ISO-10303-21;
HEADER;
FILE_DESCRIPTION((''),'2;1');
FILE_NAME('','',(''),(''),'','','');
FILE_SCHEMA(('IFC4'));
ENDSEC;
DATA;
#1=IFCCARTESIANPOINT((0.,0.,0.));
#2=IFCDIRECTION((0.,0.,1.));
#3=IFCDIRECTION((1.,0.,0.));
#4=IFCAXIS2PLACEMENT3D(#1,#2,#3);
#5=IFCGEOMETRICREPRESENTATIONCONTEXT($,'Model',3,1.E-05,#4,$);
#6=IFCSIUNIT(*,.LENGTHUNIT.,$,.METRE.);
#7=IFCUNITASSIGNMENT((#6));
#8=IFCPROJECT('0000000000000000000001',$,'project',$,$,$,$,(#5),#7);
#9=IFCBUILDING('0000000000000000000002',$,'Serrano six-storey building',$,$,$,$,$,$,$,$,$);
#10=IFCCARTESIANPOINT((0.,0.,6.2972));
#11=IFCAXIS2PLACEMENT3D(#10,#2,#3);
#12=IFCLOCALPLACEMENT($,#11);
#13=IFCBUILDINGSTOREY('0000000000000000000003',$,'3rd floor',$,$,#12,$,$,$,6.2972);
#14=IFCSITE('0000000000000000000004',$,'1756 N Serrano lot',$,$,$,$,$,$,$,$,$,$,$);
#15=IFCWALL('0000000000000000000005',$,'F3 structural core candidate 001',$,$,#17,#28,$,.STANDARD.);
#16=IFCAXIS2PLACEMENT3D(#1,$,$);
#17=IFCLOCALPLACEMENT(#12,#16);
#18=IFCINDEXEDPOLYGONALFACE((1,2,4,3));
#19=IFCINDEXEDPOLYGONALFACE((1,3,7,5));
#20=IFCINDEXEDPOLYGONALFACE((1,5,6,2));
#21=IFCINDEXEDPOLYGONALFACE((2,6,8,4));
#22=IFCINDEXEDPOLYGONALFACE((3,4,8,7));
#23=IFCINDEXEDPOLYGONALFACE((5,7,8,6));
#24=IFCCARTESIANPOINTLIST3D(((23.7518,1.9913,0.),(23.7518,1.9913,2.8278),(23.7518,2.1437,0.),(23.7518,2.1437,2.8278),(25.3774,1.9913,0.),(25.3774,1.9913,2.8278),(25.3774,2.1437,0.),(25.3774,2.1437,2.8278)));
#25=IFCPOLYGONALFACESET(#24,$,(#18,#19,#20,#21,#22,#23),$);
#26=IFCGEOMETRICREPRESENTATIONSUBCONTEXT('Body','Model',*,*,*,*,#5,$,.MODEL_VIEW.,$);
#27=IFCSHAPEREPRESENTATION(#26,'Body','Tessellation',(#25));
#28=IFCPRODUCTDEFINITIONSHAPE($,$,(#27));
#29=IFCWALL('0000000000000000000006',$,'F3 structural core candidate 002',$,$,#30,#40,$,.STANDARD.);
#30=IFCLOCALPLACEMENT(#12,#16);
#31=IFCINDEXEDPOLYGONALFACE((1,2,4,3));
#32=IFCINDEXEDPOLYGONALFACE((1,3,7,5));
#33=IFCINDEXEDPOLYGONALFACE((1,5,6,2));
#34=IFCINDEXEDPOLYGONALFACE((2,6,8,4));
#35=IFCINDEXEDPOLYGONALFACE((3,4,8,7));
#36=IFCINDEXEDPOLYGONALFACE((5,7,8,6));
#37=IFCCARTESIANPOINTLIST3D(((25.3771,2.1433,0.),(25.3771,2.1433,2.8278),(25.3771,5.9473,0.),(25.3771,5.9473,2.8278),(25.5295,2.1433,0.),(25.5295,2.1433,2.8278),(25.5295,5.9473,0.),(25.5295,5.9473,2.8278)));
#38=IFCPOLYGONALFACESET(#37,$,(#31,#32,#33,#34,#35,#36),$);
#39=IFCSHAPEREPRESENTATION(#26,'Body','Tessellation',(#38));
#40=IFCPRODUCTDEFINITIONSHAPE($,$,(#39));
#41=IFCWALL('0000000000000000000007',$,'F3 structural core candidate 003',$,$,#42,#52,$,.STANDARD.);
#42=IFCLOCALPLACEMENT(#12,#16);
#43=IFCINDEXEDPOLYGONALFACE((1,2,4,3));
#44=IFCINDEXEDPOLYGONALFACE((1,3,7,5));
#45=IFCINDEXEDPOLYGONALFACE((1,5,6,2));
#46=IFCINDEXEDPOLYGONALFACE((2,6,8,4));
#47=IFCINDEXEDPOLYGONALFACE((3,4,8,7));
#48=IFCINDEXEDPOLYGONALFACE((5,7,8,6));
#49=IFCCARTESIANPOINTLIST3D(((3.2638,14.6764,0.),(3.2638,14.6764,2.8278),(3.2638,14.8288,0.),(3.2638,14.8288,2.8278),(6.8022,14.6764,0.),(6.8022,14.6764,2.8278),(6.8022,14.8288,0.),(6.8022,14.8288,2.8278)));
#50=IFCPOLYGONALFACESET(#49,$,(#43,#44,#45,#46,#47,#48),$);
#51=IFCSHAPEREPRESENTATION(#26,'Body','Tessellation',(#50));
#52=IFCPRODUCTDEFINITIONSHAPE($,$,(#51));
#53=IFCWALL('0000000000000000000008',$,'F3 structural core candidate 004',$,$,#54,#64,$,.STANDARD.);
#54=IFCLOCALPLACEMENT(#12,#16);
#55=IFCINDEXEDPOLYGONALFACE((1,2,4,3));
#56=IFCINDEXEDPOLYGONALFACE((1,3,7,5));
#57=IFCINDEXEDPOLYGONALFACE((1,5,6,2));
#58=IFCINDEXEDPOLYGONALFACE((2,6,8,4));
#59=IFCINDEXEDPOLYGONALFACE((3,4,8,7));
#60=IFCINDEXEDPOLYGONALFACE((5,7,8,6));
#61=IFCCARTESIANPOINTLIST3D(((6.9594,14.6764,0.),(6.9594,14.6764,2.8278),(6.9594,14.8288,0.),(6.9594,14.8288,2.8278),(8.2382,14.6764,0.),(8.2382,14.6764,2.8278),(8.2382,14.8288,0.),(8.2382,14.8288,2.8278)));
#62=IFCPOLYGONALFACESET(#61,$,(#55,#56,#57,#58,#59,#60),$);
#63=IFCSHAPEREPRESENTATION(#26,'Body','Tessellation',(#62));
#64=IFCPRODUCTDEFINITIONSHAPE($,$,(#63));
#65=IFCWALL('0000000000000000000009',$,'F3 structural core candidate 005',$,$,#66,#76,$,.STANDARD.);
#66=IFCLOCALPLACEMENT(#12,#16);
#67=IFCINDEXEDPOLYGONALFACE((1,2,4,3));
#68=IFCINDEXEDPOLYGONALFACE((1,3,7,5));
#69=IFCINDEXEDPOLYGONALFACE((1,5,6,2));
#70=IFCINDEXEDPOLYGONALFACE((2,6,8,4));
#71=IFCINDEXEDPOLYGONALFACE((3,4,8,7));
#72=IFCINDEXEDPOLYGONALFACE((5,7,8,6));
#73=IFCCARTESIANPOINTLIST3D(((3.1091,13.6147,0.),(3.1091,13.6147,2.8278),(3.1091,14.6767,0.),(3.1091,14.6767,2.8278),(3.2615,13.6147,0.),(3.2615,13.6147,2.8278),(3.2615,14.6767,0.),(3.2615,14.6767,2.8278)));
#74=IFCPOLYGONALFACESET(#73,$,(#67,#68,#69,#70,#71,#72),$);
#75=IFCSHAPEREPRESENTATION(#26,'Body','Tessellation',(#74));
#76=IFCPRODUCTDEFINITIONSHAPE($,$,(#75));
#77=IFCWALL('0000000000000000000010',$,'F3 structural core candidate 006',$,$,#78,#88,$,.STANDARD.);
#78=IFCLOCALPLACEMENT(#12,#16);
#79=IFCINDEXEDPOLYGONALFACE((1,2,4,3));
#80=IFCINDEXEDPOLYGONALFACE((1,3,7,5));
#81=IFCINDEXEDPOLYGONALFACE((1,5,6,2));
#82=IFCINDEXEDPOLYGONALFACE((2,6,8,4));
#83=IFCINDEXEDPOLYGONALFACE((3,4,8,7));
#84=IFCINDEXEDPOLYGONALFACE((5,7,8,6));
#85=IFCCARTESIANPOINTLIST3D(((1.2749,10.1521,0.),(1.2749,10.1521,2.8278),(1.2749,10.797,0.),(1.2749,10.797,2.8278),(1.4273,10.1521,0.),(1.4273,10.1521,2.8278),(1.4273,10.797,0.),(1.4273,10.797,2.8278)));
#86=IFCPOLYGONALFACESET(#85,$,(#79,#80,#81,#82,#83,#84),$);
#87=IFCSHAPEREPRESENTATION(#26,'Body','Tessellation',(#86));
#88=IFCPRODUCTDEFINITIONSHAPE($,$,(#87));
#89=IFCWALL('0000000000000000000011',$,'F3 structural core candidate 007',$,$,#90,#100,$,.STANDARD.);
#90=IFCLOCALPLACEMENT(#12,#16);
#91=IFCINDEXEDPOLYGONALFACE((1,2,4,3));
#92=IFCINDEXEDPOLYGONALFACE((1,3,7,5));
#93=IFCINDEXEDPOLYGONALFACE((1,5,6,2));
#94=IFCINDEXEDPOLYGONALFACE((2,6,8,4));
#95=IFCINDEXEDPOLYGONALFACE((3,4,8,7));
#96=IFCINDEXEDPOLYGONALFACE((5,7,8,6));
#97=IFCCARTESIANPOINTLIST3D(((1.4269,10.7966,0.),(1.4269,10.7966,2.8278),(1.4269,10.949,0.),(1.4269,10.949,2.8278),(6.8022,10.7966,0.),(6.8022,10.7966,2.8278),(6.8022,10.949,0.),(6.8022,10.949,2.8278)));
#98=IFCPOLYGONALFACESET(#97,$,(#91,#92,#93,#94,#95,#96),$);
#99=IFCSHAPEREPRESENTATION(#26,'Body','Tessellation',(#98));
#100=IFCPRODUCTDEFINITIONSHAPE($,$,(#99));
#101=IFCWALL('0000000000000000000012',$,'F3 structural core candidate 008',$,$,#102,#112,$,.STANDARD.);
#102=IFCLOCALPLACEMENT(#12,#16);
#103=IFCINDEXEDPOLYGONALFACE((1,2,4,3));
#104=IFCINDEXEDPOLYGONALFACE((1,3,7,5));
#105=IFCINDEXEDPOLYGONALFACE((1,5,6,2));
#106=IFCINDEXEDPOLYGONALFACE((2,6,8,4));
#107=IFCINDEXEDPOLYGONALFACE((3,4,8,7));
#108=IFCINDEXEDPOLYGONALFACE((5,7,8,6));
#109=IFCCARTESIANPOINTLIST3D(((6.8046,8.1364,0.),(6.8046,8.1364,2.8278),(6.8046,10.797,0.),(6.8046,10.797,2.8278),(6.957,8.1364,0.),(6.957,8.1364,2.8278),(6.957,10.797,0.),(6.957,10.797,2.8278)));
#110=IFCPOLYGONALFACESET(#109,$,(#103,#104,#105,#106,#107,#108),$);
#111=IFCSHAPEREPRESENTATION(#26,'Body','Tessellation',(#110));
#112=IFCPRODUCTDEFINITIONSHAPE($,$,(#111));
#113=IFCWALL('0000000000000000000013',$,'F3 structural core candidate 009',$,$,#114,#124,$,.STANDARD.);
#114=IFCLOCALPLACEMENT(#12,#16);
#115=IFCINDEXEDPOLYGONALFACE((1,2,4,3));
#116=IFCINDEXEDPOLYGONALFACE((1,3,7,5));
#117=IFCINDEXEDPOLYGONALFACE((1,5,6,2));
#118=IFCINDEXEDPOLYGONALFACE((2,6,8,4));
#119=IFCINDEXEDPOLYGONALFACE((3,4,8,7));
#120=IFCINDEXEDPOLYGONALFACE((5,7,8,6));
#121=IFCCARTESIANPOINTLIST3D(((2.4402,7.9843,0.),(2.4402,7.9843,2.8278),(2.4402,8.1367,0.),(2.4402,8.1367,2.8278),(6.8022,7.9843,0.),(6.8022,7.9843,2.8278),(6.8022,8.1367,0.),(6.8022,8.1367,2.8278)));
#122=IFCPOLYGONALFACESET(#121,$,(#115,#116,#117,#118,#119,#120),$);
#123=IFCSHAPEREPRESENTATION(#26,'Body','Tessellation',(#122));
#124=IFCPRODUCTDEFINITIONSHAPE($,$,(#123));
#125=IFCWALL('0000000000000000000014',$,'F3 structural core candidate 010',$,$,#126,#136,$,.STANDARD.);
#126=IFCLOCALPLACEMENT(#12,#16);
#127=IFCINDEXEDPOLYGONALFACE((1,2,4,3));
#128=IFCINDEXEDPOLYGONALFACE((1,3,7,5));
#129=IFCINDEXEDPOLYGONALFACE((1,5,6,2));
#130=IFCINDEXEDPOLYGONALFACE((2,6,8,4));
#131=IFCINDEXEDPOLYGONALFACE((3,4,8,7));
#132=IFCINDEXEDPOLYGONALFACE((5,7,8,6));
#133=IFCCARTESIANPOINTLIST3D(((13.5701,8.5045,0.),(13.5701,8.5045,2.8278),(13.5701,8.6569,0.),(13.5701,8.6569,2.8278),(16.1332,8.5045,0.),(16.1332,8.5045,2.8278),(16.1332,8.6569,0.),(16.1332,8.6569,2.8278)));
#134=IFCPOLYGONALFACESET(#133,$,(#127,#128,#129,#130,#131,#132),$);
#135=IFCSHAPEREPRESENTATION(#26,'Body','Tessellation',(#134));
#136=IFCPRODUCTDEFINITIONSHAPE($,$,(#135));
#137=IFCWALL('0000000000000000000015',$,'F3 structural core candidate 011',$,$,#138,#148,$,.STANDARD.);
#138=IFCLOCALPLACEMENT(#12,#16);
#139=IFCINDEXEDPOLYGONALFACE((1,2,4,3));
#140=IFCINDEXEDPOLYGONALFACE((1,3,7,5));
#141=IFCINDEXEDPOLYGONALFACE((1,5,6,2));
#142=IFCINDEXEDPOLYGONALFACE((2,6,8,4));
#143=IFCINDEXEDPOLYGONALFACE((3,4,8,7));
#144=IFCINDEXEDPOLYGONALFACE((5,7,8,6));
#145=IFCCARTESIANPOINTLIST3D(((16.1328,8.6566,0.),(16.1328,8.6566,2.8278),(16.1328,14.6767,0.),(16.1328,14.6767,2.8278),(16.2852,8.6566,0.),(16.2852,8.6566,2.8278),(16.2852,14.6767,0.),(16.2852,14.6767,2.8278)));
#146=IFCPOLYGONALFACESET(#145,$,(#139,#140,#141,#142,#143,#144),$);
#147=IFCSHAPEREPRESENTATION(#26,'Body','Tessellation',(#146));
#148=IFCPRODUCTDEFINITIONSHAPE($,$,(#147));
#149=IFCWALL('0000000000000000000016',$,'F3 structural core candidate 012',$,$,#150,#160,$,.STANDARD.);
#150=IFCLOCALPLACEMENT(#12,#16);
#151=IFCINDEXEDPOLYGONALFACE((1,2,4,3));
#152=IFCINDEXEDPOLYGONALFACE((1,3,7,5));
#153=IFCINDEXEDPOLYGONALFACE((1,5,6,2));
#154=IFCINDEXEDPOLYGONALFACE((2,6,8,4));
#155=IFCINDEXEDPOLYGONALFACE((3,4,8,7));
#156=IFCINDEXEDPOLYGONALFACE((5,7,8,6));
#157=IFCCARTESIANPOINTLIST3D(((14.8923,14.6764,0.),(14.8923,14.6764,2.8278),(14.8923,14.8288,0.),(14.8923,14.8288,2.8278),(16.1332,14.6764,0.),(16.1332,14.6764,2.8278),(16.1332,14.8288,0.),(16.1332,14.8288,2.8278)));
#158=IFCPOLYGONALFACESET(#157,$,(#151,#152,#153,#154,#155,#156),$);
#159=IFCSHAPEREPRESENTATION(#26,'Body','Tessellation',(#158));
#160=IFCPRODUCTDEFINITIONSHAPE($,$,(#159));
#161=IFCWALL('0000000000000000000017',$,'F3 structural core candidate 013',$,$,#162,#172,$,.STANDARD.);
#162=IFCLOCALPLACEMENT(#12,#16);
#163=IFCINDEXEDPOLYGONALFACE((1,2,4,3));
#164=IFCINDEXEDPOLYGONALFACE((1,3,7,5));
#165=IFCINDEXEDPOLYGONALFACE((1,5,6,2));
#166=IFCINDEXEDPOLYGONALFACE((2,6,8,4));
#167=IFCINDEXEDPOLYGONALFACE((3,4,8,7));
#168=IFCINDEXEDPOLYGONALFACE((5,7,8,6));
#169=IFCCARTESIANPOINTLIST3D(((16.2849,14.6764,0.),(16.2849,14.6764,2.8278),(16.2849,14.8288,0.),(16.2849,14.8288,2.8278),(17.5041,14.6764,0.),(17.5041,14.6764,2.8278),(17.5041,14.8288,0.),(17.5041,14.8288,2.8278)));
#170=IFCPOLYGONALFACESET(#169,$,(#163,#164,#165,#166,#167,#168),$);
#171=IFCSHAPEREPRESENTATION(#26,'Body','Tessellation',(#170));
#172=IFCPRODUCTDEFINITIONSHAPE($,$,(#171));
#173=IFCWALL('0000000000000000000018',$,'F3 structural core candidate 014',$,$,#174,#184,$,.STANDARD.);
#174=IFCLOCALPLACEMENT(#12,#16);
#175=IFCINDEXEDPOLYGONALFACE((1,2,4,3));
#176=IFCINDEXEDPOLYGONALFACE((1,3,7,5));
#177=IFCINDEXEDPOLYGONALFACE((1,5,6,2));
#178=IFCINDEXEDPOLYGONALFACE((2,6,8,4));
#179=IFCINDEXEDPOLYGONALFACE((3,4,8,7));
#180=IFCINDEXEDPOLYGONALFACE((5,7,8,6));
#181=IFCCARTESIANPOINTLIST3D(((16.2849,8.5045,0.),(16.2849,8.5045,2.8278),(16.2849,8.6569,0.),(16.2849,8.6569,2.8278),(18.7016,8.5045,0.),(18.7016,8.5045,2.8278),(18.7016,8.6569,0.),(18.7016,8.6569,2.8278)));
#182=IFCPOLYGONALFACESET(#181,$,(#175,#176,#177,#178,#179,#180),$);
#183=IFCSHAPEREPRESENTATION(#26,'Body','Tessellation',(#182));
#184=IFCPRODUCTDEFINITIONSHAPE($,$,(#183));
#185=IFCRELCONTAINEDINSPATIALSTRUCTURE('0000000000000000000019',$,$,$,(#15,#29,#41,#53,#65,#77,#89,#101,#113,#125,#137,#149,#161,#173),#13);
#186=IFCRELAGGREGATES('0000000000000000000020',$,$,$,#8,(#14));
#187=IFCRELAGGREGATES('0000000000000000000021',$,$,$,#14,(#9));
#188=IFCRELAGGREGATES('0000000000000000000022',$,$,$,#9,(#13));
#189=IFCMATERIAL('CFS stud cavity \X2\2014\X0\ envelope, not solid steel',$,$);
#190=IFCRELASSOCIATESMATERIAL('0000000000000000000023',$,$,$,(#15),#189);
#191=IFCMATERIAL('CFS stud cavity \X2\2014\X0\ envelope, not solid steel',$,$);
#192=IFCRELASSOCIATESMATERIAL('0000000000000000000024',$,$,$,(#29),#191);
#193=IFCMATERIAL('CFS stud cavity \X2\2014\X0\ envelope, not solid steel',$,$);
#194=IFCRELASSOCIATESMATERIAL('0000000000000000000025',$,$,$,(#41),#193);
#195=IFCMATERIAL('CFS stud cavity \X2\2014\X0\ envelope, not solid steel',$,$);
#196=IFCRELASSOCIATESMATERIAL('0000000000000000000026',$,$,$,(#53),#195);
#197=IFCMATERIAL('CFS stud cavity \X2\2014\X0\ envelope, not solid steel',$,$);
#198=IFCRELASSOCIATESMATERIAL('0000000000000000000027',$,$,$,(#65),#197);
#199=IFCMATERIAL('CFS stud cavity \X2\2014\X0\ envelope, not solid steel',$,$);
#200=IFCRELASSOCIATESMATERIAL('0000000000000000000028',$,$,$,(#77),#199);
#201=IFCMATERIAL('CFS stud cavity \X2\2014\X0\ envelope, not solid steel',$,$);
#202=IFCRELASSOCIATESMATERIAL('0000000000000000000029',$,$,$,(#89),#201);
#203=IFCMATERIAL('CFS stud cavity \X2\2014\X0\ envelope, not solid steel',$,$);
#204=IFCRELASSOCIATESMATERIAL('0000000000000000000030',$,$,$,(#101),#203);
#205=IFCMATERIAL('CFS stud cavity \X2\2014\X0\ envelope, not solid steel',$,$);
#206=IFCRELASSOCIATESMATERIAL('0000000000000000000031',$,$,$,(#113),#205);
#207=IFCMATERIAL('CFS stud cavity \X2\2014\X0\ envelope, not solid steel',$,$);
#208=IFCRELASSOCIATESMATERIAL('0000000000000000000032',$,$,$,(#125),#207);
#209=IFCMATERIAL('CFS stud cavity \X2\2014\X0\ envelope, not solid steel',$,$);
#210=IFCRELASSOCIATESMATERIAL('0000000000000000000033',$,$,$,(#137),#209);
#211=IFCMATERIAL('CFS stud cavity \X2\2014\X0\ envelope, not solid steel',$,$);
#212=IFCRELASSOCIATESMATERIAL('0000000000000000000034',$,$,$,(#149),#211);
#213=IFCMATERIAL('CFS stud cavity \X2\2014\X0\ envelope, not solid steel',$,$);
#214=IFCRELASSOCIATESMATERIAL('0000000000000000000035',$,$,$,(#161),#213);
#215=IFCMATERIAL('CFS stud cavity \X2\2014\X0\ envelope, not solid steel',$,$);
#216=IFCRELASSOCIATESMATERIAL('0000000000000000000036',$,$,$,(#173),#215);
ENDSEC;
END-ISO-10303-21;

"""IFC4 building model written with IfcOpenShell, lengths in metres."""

from ifc_helpers import new_model, si_unit, frame, origin_with_axes, place, context, subcontext, project, spatial, polyline, outline, extrude, material, element, save


model = new_model("IFC4")

# Units and contexts
model_context = context("Model", 3, precision=1e-05, world=origin_with_axes())
body_context = subcontext(model_context, "Body", "Model", "MODEL_VIEW")
ifc_project = project(units=[si_unit("LENGTHUNIT", "METRE")], contexts=[model_context])

# Site, building, storey
site = spatial("IfcSite", under=ifc_project, Name="1756 N Serrano lot")
building = spatial("IfcBuilding", under=site, Name="Serrano six-storey building")
storey_placement = place(None, frame((0.0, 0.0, 6.2972), z_axis=(0.0, 0.0, 1.0), x_axis=(1.0, 0.0, 0.0)))
storey = spatial("IfcBuildingStorey", under=building, at=storey_placement, Name="3rd floor", Elevation=6.2972)

# Walls
ifc_material_1 = material(Name="CFS stud cavity — envelope, not solid steel")
wall_1_placement = place(storey_placement, frame((0.0, 0.0, -6.2972), z_axis=(0.0, 0.0, 1.0), x_axis=(1.0, 0.0, 0.0)))
element("IfcWall", 1, at=wall_1_placement, inside=storey, material=ifc_material_1, Name="F3 structural core candidate 001", PredefinedType="STANDARD", context=body_context, shape_type="SweptSolid", body=[
    extrude(outline(polyline([(25.3774, 2.1437), (25.3774, 1.9913), (23.7518, 1.9913), (23.7518, 2.1437), (25.3774, 2.1437)])), frame((0.0, 0.0, 6.2972)), (0.0, 0.0, 1.0), 2.8278),
])
ifc_material_2 = material(Name="CFS stud cavity — envelope, not solid steel")
wall_2_placement = place(storey_placement, frame((0.0, 0.0, -6.2972), z_axis=(0.0, 0.0, 1.0), x_axis=(1.0, 0.0, 0.0)))
element("IfcWall", 2, at=wall_2_placement, inside=storey, material=ifc_material_2, Name="F3 structural core candidate 002", PredefinedType="STANDARD", context=body_context, shape_type="SweptSolid", body=[
    extrude(outline(polyline([(25.5295, 2.1433), (25.3771, 2.1433), (25.3771, 5.9473), (25.5295, 5.9473), (25.5295, 2.1433)])), frame((0.0, 0.0, 6.2972)), (0.0, 0.0, 1.0), 2.8278),
])
ifc_material_3 = material(Name="CFS stud cavity — envelope, not solid steel")
wall_3_placement = place(storey_placement, frame((0.0, 0.0, -6.2972), z_axis=(0.0, 0.0, 1.0), x_axis=(1.0, 0.0, 0.0)))
element("IfcWall", 3, at=wall_3_placement, inside=storey, material=ifc_material_3, Name="F3 structural core candidate 003", PredefinedType="STANDARD", context=body_context, shape_type="SweptSolid", body=[
    extrude(outline(polyline([(6.8022, 14.8288), (6.8022, 14.6764), (3.2638, 14.6764), (3.2638, 14.8288), (6.8022, 14.8288)])), frame((0.0, 0.0, 6.2972)), (0.0, 0.0, 1.0), 2.8278),
])
ifc_material_4 = material(Name="CFS stud cavity — envelope, not solid steel")
wall_4_placement = place(storey_placement, frame((0.0, 0.0, -6.2972), z_axis=(0.0, 0.0, 1.0), x_axis=(1.0, 0.0, 0.0)))
element("IfcWall", 4, at=wall_4_placement, inside=storey, material=ifc_material_4, Name="F3 structural core candidate 004", PredefinedType="STANDARD", context=body_context, shape_type="SweptSolid", body=[
    extrude(outline(polyline([(8.2382, 14.8288), (8.2382, 14.6764), (6.9594, 14.6764), (6.9594, 14.8288), (8.2382, 14.8288)])), frame((0.0, 0.0, 6.2972)), (0.0, 0.0, 1.0), 2.8278),
])
ifc_material_5 = material(Name="CFS stud cavity — envelope, not solid steel")
wall_5_placement = place(storey_placement, frame((0.0, 0.0, -6.2972), z_axis=(0.0, 0.0, 1.0), x_axis=(1.0, 0.0, 0.0)))
element("IfcWall", 5, at=wall_5_placement, inside=storey, material=ifc_material_5, Name="F3 structural core candidate 005", PredefinedType="STANDARD", context=body_context, shape_type="SweptSolid", body=[
    extrude(outline(polyline([(3.2615, 13.6147), (3.1091, 13.6147), (3.1091, 14.6767), (3.2615, 14.6767), (3.2615, 13.6147)])), frame((0.0, 0.0, 6.2972)), (0.0, 0.0, 1.0), 2.8278),
])
ifc_material_6 = material(Name="CFS stud cavity — envelope, not solid steel")
wall_6_placement = place(storey_placement, frame((0.0, 0.0, -6.2972), z_axis=(0.0, 0.0, 1.0), x_axis=(1.0, 0.0, 0.0)))
element("IfcWall", 6, at=wall_6_placement, inside=storey, material=ifc_material_6, Name="F3 structural core candidate 006", PredefinedType="STANDARD", context=body_context, shape_type="SweptSolid", body=[
    extrude(outline(polyline([(1.4273, 10.1521), (1.2749, 10.1521), (1.2749, 10.797), (1.4273, 10.797), (1.4273, 10.1521)])), frame((0.0, 0.0, 6.2972)), (0.0, 0.0, 1.0), 2.8278),
])
ifc_material_7 = material(Name="CFS stud cavity — envelope, not solid steel")
wall_7_placement = place(storey_placement, frame((0.0, 0.0, -6.2972), z_axis=(0.0, 0.0, 1.0), x_axis=(1.0, 0.0, 0.0)))
element("IfcWall", 7, at=wall_7_placement, inside=storey, material=ifc_material_7, Name="F3 structural core candidate 007", PredefinedType="STANDARD", context=body_context, shape_type="SweptSolid", body=[
    extrude(outline(polyline([(6.8022, 10.949), (6.8022, 10.7966), (1.4269, 10.7966), (1.4269, 10.949), (6.8022, 10.949)])), frame((0.0, 0.0, 6.2972)), (0.0, 0.0, 1.0), 2.8278),
])
ifc_material_8 = material(Name="CFS stud cavity — envelope, not solid steel")
wall_8_placement = place(storey_placement, frame((0.0, 0.0, -6.2972), z_axis=(0.0, 0.0, 1.0), x_axis=(1.0, 0.0, 0.0)))
element("IfcWall", 8, at=wall_8_placement, inside=storey, material=ifc_material_8, Name="F3 structural core candidate 008", PredefinedType="STANDARD", context=body_context, shape_type="SweptSolid", body=[
    extrude(outline(polyline([(6.957, 8.1364), (6.8046, 8.1364), (6.8046, 10.797), (6.957, 10.797), (6.957, 8.1364)])), frame((0.0, 0.0, 6.2972)), (0.0, 0.0, 1.0), 2.8278),
])
ifc_material_9 = material(Name="CFS stud cavity — envelope, not solid steel")
wall_9_placement = place(storey_placement, frame((0.0, 0.0, -6.2972), z_axis=(0.0, 0.0, 1.0), x_axis=(1.0, 0.0, 0.0)))
element("IfcWall", 9, at=wall_9_placement, inside=storey, material=ifc_material_9, Name="F3 structural core candidate 009", PredefinedType="STANDARD", context=body_context, shape_type="SweptSolid", body=[
    extrude(outline(polyline([(6.8022, 8.1367), (6.8022, 7.9843), (2.4402, 7.9843), (2.4402, 8.1367), (6.8022, 8.1367)])), frame((0.0, 0.0, 6.2972)), (0.0, 0.0, 1.0), 2.8278),
])
ifc_material_10 = material(Name="CFS stud cavity — envelope, not solid steel")
wall_10_placement = place(storey_placement, frame((0.0, 0.0, -6.2972), z_axis=(0.0, 0.0, 1.0), x_axis=(1.0, 0.0, 0.0)))
element("IfcWall", 10, at=wall_10_placement, inside=storey, material=ifc_material_10, Name="F3 structural core candidate 010", PredefinedType="STANDARD", context=body_context, shape_type="SweptSolid", body=[
    extrude(outline(polyline([(16.1332, 8.6569), (16.1332, 8.5045), (13.5701, 8.5045), (13.5701, 8.6569), (16.1332, 8.6569)])), frame((0.0, 0.0, 6.2972)), (0.0, 0.0, 1.0), 2.8278),
])
ifc_material_11 = material(Name="CFS stud cavity — envelope, not solid steel")
wall_11_placement = place(storey_placement, frame((0.0, 0.0, -6.2972), z_axis=(0.0, 0.0, 1.0), x_axis=(1.0, 0.0, 0.0)))
element("IfcWall", 11, at=wall_11_placement, inside=storey, material=ifc_material_11, Name="F3 structural core candidate 011", PredefinedType="STANDARD", context=body_context, shape_type="SweptSolid", body=[
    extrude(outline(polyline([(16.2852, 8.6566), (16.1328, 8.6566), (16.1328, 14.6767), (16.2852, 14.6767), (16.2852, 8.6566)])), frame((0.0, 0.0, 6.2972)), (0.0, 0.0, 1.0), 2.8278),
])
ifc_material_12 = material(Name="CFS stud cavity — envelope, not solid steel")
wall_12_placement = place(storey_placement, frame((0.0, 0.0, -6.2972), z_axis=(0.0, 0.0, 1.0), x_axis=(1.0, 0.0, 0.0)))
element("IfcWall", 12, at=wall_12_placement, inside=storey, material=ifc_material_12, Name="F3 structural core candidate 012", PredefinedType="STANDARD", context=body_context, shape_type="SweptSolid", body=[
    extrude(outline(polyline([(16.1332, 14.8288), (16.1332, 14.6764), (14.8923, 14.6764), (14.8923, 14.8288), (16.1332, 14.8288)])), frame((0.0, 0.0, 6.2972)), (0.0, 0.0, 1.0), 2.8278),
])
ifc_material_13 = material(Name="CFS stud cavity — envelope, not solid steel")
wall_13_placement = place(storey_placement, frame((0.0, 0.0, -6.2972), z_axis=(0.0, 0.0, 1.0), x_axis=(1.0, 0.0, 0.0)))
element("IfcWall", 13, at=wall_13_placement, inside=storey, material=ifc_material_13, Name="F3 structural core candidate 013", PredefinedType="STANDARD", context=body_context, shape_type="SweptSolid", body=[
    extrude(outline(polyline([(17.5041, 14.8288), (17.5041, 14.6764), (16.2849, 14.6764), (16.2849, 14.8288), (17.5041, 14.8288)])), frame((0.0, 0.0, 6.2972)), (0.0, 0.0, 1.0), 2.8278),
])
ifc_material_14 = material(Name="CFS stud cavity — envelope, not solid steel")
wall_14_placement = place(storey_placement, frame((0.0, 0.0, -6.2972), z_axis=(0.0, 0.0, 1.0), x_axis=(1.0, 0.0, 0.0)))
element("IfcWall", 14, at=wall_14_placement, inside=storey, material=ifc_material_14, Name="F3 structural core candidate 014", PredefinedType="STANDARD", context=body_context, shape_type="SweptSolid", body=[
    extrude(outline(polyline([(18.7016, 8.6569), (18.7016, 8.5045), (16.2849, 8.5045), (16.2849, 8.6569), (18.7016, 8.6569)])), frame((0.0, 0.0, 6.2972)), (0.0, 0.0, 1.0), 2.8278),
])

save(model, "model.ifc")
